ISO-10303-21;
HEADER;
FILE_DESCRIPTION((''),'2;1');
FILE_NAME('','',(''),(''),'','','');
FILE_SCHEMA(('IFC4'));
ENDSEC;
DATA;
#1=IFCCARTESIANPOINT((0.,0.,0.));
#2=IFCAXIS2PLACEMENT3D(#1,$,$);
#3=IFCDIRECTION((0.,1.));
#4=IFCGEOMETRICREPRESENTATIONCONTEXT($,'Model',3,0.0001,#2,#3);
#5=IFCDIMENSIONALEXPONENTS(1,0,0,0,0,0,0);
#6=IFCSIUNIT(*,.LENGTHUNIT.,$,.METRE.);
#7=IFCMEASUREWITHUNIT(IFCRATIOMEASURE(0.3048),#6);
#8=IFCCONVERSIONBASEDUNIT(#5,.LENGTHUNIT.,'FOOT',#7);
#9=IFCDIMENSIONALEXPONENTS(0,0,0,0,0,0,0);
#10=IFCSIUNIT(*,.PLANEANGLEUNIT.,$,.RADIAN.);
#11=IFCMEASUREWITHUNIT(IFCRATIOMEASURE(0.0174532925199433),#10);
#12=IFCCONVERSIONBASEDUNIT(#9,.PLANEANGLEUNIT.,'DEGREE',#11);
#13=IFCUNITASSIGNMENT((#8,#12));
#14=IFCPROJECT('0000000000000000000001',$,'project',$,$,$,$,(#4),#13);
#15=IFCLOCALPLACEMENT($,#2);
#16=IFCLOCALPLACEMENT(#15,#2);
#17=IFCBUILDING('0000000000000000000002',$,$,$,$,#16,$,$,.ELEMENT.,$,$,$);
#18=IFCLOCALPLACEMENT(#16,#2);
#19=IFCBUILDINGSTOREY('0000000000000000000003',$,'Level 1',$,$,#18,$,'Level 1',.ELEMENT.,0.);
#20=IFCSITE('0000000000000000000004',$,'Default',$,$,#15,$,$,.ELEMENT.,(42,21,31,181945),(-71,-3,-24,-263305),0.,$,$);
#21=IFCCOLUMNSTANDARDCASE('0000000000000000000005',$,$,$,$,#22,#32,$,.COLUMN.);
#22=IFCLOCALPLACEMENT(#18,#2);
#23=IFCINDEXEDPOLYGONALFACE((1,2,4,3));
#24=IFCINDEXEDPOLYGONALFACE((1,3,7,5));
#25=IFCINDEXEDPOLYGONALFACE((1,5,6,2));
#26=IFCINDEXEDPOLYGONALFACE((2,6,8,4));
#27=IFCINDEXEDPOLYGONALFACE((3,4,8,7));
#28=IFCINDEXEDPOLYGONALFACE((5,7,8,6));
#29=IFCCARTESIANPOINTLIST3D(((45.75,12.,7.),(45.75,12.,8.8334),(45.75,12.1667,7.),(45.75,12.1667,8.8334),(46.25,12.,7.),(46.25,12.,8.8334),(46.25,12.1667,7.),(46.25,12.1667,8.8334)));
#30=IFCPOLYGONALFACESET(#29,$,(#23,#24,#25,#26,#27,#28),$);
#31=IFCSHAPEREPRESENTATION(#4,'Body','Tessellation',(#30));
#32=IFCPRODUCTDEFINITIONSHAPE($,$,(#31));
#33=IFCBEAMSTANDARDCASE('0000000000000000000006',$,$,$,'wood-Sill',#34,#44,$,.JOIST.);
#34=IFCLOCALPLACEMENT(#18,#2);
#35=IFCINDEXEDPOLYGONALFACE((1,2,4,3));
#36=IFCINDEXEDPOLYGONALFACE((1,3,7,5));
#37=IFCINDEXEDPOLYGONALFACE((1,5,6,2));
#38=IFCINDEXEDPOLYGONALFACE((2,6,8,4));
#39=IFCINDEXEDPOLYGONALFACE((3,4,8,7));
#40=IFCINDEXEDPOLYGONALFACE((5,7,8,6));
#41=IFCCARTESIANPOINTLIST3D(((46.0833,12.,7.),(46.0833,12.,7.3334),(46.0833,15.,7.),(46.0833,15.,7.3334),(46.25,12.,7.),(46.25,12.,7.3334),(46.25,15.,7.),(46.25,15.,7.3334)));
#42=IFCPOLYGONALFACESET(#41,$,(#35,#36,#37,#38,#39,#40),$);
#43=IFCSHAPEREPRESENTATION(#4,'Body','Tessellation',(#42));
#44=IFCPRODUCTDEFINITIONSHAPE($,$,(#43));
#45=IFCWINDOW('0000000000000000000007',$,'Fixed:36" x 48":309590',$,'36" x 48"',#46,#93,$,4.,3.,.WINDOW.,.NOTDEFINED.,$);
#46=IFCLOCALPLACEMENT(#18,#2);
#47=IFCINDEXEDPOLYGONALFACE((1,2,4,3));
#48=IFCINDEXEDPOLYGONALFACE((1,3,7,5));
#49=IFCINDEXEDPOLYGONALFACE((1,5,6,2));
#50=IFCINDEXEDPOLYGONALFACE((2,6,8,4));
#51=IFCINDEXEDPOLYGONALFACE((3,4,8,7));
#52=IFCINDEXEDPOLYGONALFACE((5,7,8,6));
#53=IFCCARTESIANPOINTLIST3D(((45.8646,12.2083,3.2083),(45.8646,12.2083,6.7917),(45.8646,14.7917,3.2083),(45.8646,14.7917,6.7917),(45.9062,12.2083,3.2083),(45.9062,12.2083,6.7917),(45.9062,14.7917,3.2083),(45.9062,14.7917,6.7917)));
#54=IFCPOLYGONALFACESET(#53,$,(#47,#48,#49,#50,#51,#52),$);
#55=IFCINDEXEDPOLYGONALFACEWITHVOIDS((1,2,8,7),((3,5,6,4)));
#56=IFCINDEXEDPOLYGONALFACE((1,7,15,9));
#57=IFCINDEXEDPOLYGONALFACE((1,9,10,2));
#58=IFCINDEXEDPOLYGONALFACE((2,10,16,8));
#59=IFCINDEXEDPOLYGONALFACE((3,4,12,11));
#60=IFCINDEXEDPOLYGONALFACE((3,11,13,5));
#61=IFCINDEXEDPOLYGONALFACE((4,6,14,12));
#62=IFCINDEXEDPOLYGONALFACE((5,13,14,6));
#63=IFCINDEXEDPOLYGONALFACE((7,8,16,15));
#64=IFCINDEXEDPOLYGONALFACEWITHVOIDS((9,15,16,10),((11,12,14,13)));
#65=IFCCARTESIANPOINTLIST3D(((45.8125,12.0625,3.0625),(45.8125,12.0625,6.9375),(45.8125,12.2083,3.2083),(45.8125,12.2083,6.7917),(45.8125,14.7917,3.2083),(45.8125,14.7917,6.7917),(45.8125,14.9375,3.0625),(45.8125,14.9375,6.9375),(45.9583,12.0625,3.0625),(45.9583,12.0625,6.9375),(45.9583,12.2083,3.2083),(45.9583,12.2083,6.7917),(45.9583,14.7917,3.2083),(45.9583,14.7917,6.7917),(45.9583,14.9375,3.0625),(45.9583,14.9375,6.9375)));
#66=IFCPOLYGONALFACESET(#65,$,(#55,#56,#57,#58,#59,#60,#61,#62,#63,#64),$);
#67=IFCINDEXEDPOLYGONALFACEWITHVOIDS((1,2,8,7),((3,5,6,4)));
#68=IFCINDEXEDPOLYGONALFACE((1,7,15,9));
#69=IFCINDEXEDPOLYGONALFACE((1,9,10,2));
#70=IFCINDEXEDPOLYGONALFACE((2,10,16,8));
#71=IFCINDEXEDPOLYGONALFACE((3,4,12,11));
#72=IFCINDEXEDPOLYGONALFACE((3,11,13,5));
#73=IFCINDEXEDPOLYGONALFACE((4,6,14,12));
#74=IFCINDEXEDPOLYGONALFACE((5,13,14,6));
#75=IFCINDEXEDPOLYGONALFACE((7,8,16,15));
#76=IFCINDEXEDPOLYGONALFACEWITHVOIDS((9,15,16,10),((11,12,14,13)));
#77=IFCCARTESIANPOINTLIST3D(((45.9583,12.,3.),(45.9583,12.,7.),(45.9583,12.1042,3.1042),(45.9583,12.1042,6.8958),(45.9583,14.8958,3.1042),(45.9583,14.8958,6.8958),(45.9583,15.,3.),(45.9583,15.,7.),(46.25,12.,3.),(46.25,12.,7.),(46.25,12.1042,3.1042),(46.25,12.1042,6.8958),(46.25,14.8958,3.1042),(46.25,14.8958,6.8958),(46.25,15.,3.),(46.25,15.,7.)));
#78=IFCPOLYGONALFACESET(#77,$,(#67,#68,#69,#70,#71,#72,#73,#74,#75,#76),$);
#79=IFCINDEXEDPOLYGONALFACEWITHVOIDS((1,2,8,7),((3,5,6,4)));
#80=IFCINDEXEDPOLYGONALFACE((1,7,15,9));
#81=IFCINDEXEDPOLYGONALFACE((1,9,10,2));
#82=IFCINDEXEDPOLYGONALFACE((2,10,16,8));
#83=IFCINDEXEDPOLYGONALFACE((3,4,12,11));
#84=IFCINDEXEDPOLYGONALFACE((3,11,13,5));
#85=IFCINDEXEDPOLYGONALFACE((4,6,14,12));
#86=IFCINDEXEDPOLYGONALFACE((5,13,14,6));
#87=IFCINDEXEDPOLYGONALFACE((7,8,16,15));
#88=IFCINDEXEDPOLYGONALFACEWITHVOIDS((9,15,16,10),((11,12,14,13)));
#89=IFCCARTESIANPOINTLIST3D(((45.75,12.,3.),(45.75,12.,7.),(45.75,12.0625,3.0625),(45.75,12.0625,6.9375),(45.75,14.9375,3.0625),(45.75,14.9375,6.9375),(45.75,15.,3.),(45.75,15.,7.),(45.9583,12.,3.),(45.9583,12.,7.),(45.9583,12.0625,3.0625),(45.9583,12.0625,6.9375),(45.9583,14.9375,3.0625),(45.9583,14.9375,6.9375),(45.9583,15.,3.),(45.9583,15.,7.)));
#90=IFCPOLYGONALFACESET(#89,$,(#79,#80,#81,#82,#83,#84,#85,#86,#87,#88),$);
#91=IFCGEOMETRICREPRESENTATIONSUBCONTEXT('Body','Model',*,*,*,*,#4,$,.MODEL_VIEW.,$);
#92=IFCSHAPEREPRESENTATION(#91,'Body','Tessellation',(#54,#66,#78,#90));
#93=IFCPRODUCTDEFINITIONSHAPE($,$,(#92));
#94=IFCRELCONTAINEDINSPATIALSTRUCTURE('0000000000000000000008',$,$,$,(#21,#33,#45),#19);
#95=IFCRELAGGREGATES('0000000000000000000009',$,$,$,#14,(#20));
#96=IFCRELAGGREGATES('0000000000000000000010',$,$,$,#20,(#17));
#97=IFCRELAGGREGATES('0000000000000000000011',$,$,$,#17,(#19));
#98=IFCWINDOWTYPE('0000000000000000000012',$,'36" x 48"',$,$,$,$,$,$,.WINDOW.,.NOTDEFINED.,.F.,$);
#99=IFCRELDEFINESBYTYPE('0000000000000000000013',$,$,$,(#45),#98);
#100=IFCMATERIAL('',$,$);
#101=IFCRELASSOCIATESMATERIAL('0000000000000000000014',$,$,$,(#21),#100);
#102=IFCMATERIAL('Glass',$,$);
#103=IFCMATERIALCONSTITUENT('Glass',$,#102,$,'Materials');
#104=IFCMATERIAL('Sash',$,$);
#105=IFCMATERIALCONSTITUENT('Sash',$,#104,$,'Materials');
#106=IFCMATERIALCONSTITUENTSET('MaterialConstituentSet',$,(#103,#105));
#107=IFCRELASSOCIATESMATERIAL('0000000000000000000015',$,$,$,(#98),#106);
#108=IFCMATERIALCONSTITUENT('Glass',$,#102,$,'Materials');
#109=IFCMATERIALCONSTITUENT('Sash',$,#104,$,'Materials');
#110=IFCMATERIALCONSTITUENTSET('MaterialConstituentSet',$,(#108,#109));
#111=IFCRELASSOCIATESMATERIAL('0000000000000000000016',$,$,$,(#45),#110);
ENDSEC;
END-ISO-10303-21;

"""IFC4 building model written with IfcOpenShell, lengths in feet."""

from ifc_helpers import new_model, entity, si_unit, converted_unit, direction, frame, frame_2d, origin, origin_with_axes, place, context, subcontext, project, spatial, polyline, rectangle, outline, extrude, source, transform, mapped, material, constituent, constituent_set, type_object, type_shapes, element, save


model = new_model("IFC4")

# Units and contexts
model_context = context("Model", 3, precision=0.0001, world=origin(), true_north=direction((0.0, 1.0)))
body_context = subcontext(model_context, "Body", "Model", "MODEL_VIEW")
ifc_project = project(units=[converted_unit("LENGTHUNIT", "FOOT", entity("IfcRatioMeasure", 0.3048), si_unit("LENGTHUNIT", "METRE"), dimensions=[1, 0, 0, 0, 0, 0, 0]), converted_unit("PLANEANGLEUNIT", "DEGREE", entity("IfcRatioMeasure", 0.0174532925199433), si_unit("PLANEANGLEUNIT", "RADIAN"), dimensions=[0, 0, 0, 0, 0, 0, 0])], contexts=[model_context])

# Site, building, storey
site_placement = place(None, origin())
site = spatial("IfcSite", under=ifc_project, at=site_placement, Name="Default", CompositionType="ELEMENT", RefLatitude=(42, 21, 31, 181945), RefLongitude=(-71, -3, -24, -263305), RefElevation=0.0)
building_placement = place(site_placement, origin())
building = spatial("IfcBuilding", under=site, at=building_placement, CompositionType="ELEMENT")
storey_placement = place(building_placement, origin())
storey = spatial("IfcBuildingStorey", under=building, at=storey_placement, Name="Level 1", LongName="Level 1", CompositionType="ELEMENT", Elevation=0.0)

# Column
placement_1 = place(storey_placement, frame((46.0, 46.25, 0.0), z_axis=(0.0, 0.0, 1.0), x_axis=(0.0, -1.0, 0.0)))
ifc_material_1 = material(Name="")
for number, where, z_axis, x_axis in (
    (1, (34.1667, 0.0, 7.0), (0.0, 0.0, 1.0), (1.0, 0.0, 0.0)),
):
    element("IfcColumnStandardCase", number, at=place(placement_1, frame(where, z_axis=z_axis, x_axis=x_axis)), inside=storey, material=ifc_material_1, PredefinedType="COLUMN", context=model_context, shape_type="SweptSolid", body=[
        extrude(rectangle(XDim=0.1667, YDim=0.5), origin(), (0.0, 0.0, 1.0), 1.8334),
    ])

# Beam
for number, where, z_axis, x_axis in (
    (2, (31.25, 0.1667, 7.1667), (1.0, 0.0, 0.0), (0.0, 0.0, 1.0)),
):
    element("IfcBeamStandardCase", number, at=place(placement_1, frame(where, z_axis=z_axis, x_axis=x_axis)), inside=storey, ObjectType="wood-Sill", PredefinedType="JOIST", context=model_context, shape_type="SweptSolid", body=[
        extrude(rectangle(XDim=0.3333, YDim=0.1667), origin_with_axes(), (0.0, 0.0, 1.0), 3.0),
    ])

# Window
ifc_material_2 = material(Name="Glass")
ifc_constituent_1 = constituent(ifc_material_2, Name="Glass", Category="Materials")
ifc_material_3 = material(Name="Sash")
ifc_constituent_2 = constituent(ifc_material_3, Name="Sash", Category="Materials")
ifc_constituent_set_1 = constituent_set(constituents=[ifc_constituent_1, ifc_constituent_2], Name="MaterialConstituentSet")
ifc_constituent_3 = constituent(ifc_material_2, Name="Glass", Category="Materials")
ifc_constituent_4 = constituent(ifc_material_3, Name="Sash", Category="Materials")
ifc_constituent_set_2 = constituent_set(constituents=[ifc_constituent_3, ifc_constituent_4], Name="MaterialConstituentSet")
window_type = type_object("IfcWindowType", Name="36\" x 48\"", ParameterTakesPrecedence=False, PartitioningType="NOTDEFINED", PredefinedType="WINDOW", material=ifc_constituent_set_2)
shared_shape = source(origin(), body_context, "Body", "SweptSolid", [
    extrude(rectangle(XDim=0.0417, YDim=2.5833, at=frame_2d((0.0, 0.0), x_axis=(1.0, 0.0))), frame((1.5, 0.3646, 0.2083), z_axis=(0.0, 0.0, 1.0), x_axis=(0.0, 1.0, 0.0)), (0.0, 0.0, 1.0), 3.5833),
    extrude(outline(polyline([(-1.4375, -1.9375), (1.4375, -1.9375), (1.4375, 1.9375), (-1.4375, 1.9375), (-1.4375, -1.9375)]), holes=[polyline([(-1.2917, -1.7917), (-1.2917, 1.7917), (1.2917, 1.7917), (1.2917, -1.7917), (-1.2917, -1.7917)])]), frame((1.5, 0.2917, 2.0), z_axis=(0.0, 1.0, 0.0), x_axis=(1.0, 0.0, 0.0)), (0.0, 0.0, 1.0), 0.1458),
    extrude(outline(polyline([(-1.5, -2.0), (1.5, -2.0), (1.5, 2.0), (-1.5, 2.0), (-1.5, -2.0)]), holes=[polyline([(-1.3958, -1.8958), (-1.3958, 1.8958), (1.3958, 1.8958), (1.3958, -1.8958), (-1.3958, -1.8958)])]), frame((1.5, 0.0, 2.0), z_axis=(0.0, 1.0, 0.0), x_axis=(1.0, 0.0, 0.0)), (0.0, 0.0, 1.0), 0.2917),
    extrude(outline(polyline([(-2.0, -1.5), (2.0, -1.5), (2.0, 1.5), (-2.0, 1.5), (-2.0, -1.5)]), holes=[polyline([(-1.9375, -1.4375), (-1.9375, 1.4375), (1.9375, 1.4375), (1.9375, -1.4375), (-1.9375, -1.4375)])]), frame((1.5, 0.2917, 2.0), z_axis=(0.0, 1.0, 0.0), x_axis=(0.0, 0.0, -1.0)), (0.0, 0.0, 1.0), 0.2083),
])
type_shapes(window_type, [shared_shape])
placement_2 = place(placement_1, frame((34.25, 0.25, 3.0)))
window_placement = place(placement_2, frame((0.0, 0.0, 0.0), z_axis=(0.0, 0.0, 1.0), x_axis=(-1.0, 0.0, 0.0)))
element("IfcWindow", 3, at=window_placement, inside=storey, type_object=window_type, material=ifc_constituent_set_1, Name="Fixed:36\" x 48\":309590", ObjectType="36\" x 48\"", OverallHeight=4.0, OverallWidth=3.0, PartitioningType="NOTDEFINED", PredefinedType="WINDOW", context=body_context, shape_type="MappedRepresentation", body=[
    mapped(shared_shape, transform((0.0, 0.0, 0.0), scale=1.0)),
])

save(model, "model.ifc")
